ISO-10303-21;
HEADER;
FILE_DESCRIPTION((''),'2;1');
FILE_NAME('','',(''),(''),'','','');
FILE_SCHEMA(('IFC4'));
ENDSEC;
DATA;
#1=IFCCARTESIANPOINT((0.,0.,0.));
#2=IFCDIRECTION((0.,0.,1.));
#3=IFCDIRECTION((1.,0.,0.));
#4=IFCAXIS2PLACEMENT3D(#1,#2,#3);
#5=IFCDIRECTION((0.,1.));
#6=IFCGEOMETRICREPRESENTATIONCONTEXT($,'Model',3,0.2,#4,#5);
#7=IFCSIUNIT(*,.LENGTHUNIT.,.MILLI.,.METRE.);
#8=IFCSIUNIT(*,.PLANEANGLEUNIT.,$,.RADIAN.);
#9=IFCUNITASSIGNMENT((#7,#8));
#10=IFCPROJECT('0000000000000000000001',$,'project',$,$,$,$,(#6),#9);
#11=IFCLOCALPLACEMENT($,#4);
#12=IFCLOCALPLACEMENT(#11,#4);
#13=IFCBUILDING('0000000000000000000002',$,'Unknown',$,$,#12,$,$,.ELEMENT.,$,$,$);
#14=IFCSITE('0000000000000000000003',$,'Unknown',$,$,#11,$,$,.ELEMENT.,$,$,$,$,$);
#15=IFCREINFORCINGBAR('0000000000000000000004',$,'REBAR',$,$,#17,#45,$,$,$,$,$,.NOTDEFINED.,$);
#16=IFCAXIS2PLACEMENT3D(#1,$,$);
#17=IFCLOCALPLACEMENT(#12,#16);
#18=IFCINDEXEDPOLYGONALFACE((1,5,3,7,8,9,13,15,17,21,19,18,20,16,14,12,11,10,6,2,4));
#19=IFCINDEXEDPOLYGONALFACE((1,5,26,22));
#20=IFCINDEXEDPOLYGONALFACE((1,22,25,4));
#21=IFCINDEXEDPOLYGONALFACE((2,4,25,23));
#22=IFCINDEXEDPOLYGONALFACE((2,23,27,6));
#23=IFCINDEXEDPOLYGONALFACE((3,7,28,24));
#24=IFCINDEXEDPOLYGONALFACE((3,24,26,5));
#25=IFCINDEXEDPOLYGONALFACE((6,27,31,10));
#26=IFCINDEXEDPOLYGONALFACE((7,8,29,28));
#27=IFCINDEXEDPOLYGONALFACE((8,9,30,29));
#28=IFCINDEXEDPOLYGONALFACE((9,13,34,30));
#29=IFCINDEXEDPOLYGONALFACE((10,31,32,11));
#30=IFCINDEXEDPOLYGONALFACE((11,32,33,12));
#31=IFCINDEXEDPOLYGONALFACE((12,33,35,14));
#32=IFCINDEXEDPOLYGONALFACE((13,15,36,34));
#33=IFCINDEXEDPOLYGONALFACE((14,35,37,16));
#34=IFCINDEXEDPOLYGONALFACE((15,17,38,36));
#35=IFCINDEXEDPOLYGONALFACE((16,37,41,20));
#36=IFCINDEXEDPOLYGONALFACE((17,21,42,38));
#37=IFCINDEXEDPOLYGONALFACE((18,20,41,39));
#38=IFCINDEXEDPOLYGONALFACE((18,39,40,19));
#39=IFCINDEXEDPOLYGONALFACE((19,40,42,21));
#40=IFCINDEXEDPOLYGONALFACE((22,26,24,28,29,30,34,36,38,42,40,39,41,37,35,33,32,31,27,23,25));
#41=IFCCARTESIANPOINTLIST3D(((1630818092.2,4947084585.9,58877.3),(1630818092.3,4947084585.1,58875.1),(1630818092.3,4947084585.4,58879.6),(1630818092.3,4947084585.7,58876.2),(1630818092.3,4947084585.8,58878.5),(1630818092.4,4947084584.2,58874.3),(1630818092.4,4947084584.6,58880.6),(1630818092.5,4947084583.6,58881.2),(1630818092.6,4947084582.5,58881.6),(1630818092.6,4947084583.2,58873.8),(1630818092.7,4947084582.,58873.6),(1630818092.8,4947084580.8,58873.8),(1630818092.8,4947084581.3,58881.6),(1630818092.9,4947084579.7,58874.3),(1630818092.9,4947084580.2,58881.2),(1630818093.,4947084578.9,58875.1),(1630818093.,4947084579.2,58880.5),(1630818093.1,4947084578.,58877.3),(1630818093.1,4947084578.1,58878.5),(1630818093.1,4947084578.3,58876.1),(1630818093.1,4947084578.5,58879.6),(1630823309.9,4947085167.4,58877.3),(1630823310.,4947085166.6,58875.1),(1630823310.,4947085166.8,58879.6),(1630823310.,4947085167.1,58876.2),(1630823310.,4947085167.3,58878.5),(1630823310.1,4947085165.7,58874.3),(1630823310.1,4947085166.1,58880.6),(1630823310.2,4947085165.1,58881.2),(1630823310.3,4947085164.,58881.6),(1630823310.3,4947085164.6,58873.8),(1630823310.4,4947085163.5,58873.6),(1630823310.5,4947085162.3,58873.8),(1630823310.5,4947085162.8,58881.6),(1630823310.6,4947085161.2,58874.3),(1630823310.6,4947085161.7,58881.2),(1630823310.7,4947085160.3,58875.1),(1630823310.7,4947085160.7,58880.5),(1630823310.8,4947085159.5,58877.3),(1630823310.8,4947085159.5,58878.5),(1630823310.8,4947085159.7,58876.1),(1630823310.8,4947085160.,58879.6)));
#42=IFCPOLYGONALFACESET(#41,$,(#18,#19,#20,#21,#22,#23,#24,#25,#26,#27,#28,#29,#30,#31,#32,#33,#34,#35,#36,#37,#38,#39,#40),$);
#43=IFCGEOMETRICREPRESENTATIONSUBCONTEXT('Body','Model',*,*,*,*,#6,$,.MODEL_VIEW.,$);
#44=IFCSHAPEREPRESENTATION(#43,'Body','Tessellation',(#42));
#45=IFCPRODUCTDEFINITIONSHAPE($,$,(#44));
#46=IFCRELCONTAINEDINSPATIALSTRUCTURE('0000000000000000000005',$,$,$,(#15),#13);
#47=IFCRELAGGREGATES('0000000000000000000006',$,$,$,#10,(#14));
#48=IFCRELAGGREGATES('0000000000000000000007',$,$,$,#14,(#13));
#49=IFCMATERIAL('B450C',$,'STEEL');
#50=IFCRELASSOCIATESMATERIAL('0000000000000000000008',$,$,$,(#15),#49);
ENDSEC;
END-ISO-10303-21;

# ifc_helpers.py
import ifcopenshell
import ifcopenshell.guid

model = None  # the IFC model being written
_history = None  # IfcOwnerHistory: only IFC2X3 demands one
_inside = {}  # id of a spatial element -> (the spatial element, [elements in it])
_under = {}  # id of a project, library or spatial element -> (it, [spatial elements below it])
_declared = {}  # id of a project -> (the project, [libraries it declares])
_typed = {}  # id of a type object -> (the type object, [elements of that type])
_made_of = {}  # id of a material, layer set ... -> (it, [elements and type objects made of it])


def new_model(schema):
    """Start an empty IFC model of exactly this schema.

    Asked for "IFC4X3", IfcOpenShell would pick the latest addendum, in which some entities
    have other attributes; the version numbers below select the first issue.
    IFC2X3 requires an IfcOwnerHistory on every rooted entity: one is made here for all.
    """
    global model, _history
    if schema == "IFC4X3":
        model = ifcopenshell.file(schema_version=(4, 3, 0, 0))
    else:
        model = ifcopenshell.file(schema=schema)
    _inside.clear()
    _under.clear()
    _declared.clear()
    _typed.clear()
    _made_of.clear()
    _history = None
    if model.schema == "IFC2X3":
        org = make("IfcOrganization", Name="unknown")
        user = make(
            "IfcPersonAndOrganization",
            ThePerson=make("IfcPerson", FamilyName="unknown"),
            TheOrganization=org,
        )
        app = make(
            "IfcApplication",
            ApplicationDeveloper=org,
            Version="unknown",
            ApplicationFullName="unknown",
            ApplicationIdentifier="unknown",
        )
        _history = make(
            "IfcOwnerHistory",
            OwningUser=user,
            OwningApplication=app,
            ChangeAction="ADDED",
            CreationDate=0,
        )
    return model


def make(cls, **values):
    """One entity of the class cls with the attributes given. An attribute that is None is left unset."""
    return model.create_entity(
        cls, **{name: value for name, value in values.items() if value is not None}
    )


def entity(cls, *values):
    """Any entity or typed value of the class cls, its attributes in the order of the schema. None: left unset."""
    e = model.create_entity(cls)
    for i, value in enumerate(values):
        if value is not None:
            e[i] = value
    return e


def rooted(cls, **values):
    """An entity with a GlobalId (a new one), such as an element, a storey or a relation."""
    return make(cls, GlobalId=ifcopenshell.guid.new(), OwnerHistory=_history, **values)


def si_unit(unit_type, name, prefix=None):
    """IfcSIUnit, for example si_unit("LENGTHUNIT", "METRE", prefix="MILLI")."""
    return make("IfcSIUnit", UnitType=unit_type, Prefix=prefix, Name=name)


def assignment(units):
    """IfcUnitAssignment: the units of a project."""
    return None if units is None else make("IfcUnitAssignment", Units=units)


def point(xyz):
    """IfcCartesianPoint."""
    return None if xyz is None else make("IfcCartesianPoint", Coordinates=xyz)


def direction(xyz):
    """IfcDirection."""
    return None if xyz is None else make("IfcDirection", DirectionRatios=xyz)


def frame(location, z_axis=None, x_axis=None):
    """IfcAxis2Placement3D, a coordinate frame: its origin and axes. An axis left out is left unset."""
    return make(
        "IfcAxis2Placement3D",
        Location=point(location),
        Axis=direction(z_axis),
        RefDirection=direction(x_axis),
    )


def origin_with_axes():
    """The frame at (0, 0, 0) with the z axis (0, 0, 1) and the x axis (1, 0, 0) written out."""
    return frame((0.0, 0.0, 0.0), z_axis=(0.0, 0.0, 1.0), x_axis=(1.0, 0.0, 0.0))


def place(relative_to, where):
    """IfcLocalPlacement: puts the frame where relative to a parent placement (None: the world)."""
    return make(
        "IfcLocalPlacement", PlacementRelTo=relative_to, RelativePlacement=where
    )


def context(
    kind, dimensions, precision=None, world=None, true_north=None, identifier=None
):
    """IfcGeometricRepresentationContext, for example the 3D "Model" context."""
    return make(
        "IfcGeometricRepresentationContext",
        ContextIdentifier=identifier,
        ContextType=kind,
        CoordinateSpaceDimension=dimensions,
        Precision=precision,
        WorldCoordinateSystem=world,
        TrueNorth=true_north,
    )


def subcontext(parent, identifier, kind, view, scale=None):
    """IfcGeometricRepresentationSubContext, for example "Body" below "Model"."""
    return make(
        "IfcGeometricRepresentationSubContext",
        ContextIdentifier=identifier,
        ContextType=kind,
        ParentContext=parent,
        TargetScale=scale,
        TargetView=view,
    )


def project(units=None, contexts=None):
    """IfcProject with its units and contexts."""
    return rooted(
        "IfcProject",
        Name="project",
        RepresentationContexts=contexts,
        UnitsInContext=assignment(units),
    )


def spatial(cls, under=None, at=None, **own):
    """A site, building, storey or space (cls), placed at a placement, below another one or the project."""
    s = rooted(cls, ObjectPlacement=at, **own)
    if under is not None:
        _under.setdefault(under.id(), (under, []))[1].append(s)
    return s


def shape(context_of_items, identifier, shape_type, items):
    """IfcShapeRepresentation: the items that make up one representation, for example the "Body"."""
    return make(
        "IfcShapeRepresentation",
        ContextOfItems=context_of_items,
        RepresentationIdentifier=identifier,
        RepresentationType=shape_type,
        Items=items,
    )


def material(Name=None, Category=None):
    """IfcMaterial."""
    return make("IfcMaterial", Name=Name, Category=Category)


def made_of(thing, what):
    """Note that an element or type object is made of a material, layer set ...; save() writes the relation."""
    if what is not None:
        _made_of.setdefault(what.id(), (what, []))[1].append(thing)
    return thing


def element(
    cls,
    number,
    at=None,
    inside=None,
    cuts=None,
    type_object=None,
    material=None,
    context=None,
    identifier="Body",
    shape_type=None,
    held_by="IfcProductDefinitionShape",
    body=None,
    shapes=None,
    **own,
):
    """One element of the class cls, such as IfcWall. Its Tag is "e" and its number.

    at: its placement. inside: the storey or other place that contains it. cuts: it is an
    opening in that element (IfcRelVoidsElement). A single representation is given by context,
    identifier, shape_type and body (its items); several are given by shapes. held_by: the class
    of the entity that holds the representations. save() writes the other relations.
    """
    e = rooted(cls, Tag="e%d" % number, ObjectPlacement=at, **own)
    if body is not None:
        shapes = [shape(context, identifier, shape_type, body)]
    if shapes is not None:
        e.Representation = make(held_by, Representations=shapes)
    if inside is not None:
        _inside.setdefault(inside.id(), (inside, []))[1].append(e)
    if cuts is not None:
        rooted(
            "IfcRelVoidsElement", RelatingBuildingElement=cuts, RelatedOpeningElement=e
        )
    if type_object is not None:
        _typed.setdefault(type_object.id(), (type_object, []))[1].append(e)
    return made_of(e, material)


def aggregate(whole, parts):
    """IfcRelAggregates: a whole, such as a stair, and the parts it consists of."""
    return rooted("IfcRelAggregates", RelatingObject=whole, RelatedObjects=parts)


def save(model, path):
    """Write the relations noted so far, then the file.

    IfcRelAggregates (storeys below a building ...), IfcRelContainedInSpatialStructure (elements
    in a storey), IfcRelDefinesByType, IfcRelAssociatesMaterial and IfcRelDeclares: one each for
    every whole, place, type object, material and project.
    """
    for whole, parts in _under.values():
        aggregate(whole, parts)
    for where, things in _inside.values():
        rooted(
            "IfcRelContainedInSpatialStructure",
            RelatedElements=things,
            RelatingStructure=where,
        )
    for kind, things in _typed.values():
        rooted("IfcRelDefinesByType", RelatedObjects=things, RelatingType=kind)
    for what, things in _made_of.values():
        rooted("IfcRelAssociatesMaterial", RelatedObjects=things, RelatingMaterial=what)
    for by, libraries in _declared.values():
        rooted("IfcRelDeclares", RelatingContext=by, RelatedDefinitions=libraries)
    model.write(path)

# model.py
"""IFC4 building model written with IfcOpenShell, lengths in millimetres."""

from ifc_helpers import new_model, entity, si_unit, direction, frame, origin_with_axes, place, context, subcontext, project, spatial, material, element, save


model = new_model("IFC4")

# Units and contexts
model_context = context("Model", 3, precision=0.2, world=origin_with_axes(), true_north=direction((0.0, 1.0)))
body_context = subcontext(model_context, "Body", "Model", "MODEL_VIEW")
ifc_project = project(units=[si_unit("LENGTHUNIT", "METRE", prefix="MILLI"), si_unit("PLANEANGLEUNIT", "RADIAN")], contexts=[model_context])

# Site, building
site_placement = place(None, origin_with_axes())
site = spatial("IfcSite", under=ifc_project, at=site_placement, Name="Unknown", CompositionType="ELEMENT")
building_placement = place(site_placement, origin_with_axes())
building = spatial("IfcBuilding", under=site, at=building_placement, Name="Unknown", CompositionType="ELEMENT")

# Reinforcing bar
ifc_material = material(Name="B450C", Category="STEEL")
reinforcing_bar_1_placement = place(building_placement, frame((1630818092.7, 4947084581.9, 58877.6), z_axis=(-0.007106, 0.063762, 0.99794), x_axis=(0.993847, 0.110757, 0.0)))
element("IfcReinforcingBar", 1, at=reinforcing_bar_1_placement, inside=building, material=ifc_material, Name="REBAR", PredefinedType="NOTDEFINED", context=body_context, shape_type="AdvancedSweptSolid", body=[
    entity("IfcSweptDiskSolid", entity("IfcIndexedPolyCurve", entity("IfcCartesianPointList3D", [[0.0, 0.0, 0.0], [5250.0, 0.0, 0.0]]), [entity("IfcLineIndex", [1, 2])]), 4.0),
])

save(model, "model.ifc")
